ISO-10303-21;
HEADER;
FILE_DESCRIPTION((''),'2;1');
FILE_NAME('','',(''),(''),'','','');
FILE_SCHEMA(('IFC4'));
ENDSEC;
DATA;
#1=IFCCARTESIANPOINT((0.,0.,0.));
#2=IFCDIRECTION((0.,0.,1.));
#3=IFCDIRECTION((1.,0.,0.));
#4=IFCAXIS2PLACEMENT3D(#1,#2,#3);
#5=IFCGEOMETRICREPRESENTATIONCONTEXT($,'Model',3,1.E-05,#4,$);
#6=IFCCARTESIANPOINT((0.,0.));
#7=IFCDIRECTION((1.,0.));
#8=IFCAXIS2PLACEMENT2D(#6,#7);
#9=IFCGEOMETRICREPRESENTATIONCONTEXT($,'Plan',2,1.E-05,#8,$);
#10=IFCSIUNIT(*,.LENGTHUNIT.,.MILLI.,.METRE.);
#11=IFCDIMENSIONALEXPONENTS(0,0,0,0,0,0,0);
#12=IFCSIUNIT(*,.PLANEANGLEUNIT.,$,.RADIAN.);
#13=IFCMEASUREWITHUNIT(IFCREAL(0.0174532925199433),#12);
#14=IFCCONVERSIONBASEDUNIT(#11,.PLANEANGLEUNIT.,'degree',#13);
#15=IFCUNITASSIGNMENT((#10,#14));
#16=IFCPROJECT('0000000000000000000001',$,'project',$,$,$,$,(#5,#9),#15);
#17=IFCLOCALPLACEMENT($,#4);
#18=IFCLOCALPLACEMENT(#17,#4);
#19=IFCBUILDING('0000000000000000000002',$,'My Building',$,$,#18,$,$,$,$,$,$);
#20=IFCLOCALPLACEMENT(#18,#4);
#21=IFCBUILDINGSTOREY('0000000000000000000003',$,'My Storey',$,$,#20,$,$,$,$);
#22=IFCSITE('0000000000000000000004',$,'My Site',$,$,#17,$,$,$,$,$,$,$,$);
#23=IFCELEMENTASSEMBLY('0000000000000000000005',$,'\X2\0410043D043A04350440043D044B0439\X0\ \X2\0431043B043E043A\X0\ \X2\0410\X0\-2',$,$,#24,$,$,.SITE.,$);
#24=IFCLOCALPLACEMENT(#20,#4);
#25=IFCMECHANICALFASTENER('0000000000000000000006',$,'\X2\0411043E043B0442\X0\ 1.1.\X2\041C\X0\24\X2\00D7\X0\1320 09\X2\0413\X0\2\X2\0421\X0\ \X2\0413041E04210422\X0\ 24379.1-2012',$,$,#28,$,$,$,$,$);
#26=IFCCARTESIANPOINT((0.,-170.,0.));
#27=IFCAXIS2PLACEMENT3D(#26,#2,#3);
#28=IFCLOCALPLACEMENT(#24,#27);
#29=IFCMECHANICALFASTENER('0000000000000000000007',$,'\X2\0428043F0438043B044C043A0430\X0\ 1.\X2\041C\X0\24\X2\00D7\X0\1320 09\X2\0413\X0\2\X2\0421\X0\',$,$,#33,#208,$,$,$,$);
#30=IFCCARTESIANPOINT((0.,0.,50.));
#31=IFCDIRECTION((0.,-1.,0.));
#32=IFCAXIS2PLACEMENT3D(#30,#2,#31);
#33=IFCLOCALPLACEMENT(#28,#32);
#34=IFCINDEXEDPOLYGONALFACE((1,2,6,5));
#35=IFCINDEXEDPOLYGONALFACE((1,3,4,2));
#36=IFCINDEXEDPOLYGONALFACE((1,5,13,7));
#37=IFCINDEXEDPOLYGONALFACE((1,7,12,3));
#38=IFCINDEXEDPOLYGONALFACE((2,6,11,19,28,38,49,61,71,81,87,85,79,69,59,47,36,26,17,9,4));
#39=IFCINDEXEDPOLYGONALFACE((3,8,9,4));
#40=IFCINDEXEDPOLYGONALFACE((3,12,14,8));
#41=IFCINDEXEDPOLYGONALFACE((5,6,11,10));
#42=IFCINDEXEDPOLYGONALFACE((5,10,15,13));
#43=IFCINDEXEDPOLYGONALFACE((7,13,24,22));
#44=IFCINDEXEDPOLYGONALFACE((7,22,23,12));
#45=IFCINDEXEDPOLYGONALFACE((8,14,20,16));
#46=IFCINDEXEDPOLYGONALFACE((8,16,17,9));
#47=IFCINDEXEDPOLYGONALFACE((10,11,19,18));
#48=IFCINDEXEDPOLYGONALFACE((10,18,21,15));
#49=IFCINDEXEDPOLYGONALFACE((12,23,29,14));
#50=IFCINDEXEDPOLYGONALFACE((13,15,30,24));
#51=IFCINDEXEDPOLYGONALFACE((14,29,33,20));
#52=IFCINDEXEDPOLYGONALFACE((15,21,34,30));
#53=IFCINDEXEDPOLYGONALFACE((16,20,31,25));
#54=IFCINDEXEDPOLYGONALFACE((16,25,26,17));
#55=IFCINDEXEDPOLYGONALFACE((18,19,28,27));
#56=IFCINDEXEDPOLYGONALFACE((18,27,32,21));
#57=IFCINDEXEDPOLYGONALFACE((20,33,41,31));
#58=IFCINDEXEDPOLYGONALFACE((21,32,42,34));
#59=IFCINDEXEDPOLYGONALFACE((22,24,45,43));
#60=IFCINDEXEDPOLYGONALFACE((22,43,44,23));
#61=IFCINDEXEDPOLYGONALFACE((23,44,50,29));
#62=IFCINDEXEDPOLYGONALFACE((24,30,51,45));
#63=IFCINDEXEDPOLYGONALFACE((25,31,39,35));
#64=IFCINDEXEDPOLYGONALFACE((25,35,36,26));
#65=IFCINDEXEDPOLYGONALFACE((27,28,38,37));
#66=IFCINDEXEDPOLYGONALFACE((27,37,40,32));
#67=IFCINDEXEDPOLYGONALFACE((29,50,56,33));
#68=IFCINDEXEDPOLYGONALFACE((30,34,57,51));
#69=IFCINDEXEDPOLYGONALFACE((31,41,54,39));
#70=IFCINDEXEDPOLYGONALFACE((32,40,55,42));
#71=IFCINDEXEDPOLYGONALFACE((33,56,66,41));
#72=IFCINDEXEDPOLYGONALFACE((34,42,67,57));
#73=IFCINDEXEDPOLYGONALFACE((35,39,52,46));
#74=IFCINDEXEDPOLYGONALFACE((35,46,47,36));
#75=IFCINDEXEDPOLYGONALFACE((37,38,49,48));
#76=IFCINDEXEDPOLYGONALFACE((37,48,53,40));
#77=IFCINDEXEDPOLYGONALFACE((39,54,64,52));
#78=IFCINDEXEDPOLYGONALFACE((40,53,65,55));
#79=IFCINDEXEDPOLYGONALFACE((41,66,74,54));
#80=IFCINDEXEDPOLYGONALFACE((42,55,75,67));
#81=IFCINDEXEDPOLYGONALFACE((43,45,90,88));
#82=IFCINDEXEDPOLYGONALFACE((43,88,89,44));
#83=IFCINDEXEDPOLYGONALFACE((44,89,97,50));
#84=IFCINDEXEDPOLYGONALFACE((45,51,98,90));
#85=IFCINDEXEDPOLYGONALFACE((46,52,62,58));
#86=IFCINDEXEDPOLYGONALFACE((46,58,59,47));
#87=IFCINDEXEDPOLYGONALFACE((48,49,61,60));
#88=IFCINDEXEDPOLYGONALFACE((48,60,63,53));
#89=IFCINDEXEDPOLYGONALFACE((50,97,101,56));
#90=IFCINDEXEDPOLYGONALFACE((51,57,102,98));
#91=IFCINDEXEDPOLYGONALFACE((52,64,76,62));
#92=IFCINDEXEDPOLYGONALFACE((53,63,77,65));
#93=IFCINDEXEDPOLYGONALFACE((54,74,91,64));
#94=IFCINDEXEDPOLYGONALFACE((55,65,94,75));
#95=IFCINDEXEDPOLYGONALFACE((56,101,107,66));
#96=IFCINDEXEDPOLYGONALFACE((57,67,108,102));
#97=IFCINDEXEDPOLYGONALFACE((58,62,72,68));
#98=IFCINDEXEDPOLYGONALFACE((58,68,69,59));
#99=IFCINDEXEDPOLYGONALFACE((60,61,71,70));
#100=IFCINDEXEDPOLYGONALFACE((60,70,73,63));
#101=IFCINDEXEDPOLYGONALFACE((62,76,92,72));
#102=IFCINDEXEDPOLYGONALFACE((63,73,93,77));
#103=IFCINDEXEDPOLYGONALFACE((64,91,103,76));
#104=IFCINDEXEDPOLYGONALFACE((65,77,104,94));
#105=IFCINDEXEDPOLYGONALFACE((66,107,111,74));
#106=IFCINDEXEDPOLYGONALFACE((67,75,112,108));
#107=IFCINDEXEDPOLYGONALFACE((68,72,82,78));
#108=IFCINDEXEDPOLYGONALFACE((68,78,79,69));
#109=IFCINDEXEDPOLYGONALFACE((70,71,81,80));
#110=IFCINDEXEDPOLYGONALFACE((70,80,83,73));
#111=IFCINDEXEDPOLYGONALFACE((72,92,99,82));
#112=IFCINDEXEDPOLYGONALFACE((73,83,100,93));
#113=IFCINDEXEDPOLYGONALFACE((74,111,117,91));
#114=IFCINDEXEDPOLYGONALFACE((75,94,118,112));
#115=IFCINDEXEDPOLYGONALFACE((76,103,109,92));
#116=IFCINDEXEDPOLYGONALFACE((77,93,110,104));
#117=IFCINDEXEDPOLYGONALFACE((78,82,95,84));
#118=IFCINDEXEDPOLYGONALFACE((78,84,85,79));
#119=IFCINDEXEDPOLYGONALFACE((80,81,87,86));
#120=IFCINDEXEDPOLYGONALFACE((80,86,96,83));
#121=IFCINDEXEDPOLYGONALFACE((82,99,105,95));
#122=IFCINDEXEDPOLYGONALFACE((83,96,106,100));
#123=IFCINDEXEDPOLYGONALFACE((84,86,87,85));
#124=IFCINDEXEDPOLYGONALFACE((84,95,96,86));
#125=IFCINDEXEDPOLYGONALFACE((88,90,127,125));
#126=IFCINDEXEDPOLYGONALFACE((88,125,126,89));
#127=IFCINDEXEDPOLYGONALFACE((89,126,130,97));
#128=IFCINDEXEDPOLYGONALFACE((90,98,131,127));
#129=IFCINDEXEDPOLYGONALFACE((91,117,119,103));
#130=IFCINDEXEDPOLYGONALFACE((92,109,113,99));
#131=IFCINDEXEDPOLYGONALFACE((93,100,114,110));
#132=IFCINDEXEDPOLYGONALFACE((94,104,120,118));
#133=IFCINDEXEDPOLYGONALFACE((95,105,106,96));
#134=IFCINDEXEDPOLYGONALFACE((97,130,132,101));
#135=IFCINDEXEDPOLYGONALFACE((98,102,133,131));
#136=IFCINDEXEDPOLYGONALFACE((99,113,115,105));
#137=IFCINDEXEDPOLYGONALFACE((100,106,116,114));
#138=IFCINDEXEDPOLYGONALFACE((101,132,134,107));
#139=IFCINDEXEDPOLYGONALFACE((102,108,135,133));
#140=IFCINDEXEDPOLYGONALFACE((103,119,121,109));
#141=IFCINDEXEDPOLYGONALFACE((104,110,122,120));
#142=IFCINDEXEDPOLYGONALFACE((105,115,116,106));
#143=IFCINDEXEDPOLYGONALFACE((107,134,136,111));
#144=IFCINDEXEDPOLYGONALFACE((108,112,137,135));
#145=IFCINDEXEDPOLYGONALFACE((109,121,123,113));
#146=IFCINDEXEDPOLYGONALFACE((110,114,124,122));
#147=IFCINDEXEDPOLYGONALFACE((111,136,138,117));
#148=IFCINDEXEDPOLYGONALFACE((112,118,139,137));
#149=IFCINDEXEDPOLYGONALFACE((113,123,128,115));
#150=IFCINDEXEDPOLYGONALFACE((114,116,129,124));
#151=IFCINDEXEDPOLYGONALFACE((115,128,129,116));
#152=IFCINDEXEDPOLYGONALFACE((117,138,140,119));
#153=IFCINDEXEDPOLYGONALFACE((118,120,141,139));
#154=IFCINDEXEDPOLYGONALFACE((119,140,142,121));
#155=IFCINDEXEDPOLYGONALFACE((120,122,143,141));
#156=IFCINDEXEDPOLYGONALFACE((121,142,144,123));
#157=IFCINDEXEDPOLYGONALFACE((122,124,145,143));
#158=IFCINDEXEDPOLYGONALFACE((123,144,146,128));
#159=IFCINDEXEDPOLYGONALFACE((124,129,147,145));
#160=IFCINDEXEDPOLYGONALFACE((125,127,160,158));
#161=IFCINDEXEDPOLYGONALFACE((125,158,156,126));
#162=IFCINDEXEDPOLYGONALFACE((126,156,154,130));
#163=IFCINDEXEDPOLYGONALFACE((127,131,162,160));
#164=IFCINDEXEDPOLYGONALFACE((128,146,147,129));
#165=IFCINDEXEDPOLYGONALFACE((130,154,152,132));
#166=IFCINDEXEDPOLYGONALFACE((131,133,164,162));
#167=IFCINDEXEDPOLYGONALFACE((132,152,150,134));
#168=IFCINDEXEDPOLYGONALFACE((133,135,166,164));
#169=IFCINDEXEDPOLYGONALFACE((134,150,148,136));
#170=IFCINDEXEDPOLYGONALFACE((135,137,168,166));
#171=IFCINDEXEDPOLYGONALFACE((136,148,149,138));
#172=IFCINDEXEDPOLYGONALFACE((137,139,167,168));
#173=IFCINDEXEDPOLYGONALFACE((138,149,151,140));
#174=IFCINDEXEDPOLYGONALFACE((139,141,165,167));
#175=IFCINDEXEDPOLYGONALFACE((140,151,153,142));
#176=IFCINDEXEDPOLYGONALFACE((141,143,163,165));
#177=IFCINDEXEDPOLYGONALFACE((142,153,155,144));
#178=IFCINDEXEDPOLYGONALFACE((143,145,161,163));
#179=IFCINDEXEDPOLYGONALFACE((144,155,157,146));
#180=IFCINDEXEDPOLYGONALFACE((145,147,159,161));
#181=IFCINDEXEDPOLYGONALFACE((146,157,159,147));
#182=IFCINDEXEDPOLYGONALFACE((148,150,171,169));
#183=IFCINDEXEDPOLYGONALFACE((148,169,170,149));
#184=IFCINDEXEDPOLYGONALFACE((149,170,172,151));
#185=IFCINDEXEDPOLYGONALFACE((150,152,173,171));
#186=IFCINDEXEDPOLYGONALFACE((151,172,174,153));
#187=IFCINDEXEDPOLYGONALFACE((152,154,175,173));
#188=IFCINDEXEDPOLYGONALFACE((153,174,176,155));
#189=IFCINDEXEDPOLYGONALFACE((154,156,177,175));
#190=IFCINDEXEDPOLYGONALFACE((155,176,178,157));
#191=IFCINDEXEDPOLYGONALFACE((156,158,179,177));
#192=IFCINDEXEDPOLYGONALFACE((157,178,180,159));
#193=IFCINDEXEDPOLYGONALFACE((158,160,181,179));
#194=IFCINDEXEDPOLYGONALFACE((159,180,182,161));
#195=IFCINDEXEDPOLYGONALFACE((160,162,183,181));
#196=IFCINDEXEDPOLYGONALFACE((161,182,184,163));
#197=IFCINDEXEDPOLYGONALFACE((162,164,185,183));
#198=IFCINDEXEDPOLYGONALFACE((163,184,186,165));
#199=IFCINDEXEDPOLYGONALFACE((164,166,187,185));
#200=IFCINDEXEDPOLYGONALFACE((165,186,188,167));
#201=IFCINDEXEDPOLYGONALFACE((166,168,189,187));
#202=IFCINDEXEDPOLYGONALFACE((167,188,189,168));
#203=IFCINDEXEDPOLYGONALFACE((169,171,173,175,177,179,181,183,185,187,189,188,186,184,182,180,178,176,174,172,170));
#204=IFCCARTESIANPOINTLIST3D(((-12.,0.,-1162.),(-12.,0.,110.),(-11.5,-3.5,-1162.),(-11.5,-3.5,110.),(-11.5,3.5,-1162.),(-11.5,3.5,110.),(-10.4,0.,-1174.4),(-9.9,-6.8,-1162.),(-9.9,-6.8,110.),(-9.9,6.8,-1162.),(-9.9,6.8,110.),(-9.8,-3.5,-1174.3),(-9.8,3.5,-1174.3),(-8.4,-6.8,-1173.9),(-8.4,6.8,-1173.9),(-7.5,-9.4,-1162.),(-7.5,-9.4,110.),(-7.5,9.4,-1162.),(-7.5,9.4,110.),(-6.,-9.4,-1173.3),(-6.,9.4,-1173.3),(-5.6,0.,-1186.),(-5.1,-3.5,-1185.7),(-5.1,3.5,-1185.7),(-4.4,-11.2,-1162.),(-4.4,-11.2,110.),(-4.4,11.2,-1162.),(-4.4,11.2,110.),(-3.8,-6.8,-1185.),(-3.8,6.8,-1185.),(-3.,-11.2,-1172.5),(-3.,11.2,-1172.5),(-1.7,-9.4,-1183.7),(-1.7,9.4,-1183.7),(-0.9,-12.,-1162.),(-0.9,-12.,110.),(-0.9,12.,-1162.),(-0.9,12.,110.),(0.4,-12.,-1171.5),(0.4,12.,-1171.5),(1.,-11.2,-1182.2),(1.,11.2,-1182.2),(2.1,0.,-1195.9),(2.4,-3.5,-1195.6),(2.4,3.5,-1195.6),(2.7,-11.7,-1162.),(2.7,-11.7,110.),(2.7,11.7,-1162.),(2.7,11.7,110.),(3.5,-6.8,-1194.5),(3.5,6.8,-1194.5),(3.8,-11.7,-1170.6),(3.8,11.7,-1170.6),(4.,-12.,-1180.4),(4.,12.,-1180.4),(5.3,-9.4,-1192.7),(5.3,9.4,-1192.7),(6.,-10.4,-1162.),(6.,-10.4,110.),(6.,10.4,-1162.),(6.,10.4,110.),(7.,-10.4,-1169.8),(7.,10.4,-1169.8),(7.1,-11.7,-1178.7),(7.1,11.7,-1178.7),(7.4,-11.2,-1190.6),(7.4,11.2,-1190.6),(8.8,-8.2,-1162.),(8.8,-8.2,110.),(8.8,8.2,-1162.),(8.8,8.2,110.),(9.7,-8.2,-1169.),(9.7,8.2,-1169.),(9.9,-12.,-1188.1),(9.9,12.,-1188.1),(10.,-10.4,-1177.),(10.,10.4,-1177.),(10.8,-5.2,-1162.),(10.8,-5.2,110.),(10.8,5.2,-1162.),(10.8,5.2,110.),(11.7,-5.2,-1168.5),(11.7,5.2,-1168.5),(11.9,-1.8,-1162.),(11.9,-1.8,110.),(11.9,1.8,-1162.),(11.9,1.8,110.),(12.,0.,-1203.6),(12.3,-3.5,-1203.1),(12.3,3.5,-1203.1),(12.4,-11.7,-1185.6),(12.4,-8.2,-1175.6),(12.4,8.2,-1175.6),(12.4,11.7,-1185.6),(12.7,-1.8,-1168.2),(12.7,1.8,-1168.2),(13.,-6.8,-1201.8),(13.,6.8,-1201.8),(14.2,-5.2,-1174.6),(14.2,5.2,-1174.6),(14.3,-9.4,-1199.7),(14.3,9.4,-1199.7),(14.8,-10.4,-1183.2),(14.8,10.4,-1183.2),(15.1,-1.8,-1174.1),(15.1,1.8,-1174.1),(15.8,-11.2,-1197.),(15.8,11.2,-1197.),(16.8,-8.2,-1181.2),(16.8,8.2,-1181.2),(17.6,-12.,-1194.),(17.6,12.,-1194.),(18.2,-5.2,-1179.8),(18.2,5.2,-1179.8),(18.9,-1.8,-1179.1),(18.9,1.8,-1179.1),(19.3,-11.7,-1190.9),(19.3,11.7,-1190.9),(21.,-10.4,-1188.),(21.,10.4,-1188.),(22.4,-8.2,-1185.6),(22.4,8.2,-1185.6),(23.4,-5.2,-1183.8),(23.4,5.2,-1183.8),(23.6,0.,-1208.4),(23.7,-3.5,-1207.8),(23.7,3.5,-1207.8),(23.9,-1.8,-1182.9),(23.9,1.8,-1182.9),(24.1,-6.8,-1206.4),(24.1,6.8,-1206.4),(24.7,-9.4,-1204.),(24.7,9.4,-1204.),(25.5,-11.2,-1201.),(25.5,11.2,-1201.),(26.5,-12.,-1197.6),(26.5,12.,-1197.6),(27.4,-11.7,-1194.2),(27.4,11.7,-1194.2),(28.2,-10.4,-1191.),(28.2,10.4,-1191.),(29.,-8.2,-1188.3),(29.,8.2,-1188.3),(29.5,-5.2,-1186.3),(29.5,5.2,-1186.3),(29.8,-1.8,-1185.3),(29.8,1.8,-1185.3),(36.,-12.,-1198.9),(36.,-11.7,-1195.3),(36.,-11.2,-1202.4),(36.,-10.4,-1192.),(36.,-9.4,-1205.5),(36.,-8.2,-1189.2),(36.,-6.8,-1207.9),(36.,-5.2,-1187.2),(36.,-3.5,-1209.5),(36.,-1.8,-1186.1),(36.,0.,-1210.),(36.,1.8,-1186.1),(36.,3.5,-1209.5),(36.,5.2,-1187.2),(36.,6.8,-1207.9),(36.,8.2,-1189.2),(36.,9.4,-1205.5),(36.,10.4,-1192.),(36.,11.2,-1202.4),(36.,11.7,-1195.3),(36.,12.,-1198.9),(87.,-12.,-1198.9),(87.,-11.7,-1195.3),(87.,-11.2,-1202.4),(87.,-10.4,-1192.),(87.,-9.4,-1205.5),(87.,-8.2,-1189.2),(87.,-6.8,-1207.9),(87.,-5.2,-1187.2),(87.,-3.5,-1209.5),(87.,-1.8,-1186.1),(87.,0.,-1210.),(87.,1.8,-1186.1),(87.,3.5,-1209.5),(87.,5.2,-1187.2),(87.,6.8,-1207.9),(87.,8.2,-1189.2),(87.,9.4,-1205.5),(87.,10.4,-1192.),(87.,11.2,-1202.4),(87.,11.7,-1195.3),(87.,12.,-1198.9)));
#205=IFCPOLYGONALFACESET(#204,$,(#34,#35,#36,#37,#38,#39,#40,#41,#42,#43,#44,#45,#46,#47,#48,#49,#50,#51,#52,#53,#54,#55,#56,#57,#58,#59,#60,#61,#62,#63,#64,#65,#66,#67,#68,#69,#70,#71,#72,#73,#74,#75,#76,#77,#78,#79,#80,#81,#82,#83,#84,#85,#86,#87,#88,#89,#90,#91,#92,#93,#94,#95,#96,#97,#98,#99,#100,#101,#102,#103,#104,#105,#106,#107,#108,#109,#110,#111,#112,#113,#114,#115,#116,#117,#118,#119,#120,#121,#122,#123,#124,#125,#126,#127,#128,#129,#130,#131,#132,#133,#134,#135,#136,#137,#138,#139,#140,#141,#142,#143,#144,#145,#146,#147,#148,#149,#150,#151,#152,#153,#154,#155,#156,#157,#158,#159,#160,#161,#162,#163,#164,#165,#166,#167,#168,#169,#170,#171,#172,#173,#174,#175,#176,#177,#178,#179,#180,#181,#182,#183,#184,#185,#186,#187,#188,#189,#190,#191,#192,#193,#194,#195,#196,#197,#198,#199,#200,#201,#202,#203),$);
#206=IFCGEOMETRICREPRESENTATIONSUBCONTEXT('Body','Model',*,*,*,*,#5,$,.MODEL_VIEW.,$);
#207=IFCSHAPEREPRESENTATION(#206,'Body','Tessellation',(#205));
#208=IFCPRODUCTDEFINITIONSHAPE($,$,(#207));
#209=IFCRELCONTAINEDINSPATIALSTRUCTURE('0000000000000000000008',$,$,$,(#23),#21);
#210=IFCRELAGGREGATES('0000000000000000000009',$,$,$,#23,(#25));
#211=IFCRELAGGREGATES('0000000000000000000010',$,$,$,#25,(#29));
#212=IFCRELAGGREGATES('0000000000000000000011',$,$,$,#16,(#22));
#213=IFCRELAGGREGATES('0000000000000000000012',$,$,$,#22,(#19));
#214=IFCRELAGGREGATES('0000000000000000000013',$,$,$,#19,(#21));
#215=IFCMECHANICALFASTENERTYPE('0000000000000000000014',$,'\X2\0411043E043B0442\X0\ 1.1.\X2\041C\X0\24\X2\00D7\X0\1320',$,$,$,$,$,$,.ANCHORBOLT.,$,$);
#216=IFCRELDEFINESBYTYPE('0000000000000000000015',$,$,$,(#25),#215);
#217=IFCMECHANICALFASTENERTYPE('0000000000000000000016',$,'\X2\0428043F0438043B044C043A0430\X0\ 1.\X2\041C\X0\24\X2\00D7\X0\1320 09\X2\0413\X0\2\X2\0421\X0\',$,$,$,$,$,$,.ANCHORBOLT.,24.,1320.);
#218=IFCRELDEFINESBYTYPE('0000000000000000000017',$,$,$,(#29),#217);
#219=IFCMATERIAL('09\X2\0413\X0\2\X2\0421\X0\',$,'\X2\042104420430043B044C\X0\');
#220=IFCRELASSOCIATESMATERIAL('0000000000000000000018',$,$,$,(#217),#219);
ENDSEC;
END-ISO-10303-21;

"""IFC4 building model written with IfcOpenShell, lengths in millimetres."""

from ifc_helpers import new_model, entity, si_unit, converted_unit, frame, origin_with_axes, origin_2d_with_axis, place, context, subcontext, project, spatial, source, transform, mapped, material, type_object, type_shapes, element, aggregate, save


model = new_model("IFC4")

# Units and contexts
model_context = context("Model", 3, precision=1e-05, world=origin_with_axes())
plan_context = context("Plan", 2, precision=1e-05, world=origin_2d_with_axis())
body_context = subcontext(model_context, "Body", "Model", "MODEL_VIEW")
ifc_project = project(units=[si_unit("LENGTHUNIT", "METRE", prefix="MILLI"), converted_unit("PLANEANGLEUNIT", "degree", entity("IfcReal", 0.0174532925199433), si_unit("PLANEANGLEUNIT", "RADIAN"), dimensions=[0, 0, 0, 0, 0, 0, 0])], contexts=[model_context, plan_context])

# Site, building, storey
site_placement = place(None, origin_with_axes())
site = spatial("IfcSite", under=ifc_project, at=site_placement, Name="My Site")
building_placement = place(site_placement, origin_with_axes())
building = spatial("IfcBuilding", under=site, at=building_placement, Name="My Building")
storey_placement = place(building_placement, origin_with_axes())
storey = spatial("IfcBuildingStorey", under=building, at=storey_placement, Name="My Storey")

# Shared definitions
placement_1 = place(storey_placement, origin_with_axes())

# Element assembly, mechanical fasteners
assembly_1 = element("IfcElementAssembly", 1, at=placement_1, inside=storey, Name="Анкерный блок А-2", AssemblyPlace="SITE")
mechanical_fastener_type_1 = type_object("IfcMechanicalFastenerType", Name="Болт 1.1.М24×1320", PredefinedType="ANCHORBOLT")
mechanical_fastener_1_placement = place(placement_1, frame((0.0, -170.0, 0.0), z_axis=(0.0, 0.0, 1.0), x_axis=(1.0, 0.0, 0.0)))
mechanical_fastener_1 = element("IfcMechanicalFastener", 2, at=mechanical_fastener_1_placement, type_object=mechanical_fastener_type_1, Name="Болт 1.1.М24×1320 09Г2С ГОСТ 24379.1-2012")
ifc_material_1 = material(Name="09Г2С", Category="Сталь")
mechanical_fastener_type_2 = type_object("IfcMechanicalFastenerType", Name="Шпилька 1.М24×1320 09Г2С", NominalDiameter=24.0, NominalLength=1320.0, PredefinedType="ANCHORBOLT", material=ifc_material_1)
shared_shape_1 = source(frame((0.0, 0.0, 110.0), z_axis=(0.0, 0.0, 1.0), x_axis=(1.0, 0.0, 0.0)), body_context, "Body", "AdvancedSweptSolid", [
    entity("IfcSweptDiskSolid", entity("IfcIndexedPolyCurve", entity("IfcCartesianPointList3D", [[0.0, 0.0, 0.0], [0.0, 0.0, -1272.0], [10.5, 0.0, -1297.5], [36.0, 0.0, -1308.0], [87.0, 0.0, -1308.0]]), [entity("IfcLineIndex", [1, 2]), entity("IfcArcIndex", [2, 3, 4]), entity("IfcLineIndex", [4, 5])]), 12.0),
])
type_shapes(mechanical_fastener_type_2, [shared_shape_1])
mechanical_fastener_2_placement = place(mechanical_fastener_1_placement, frame((0.0, 0.0, 50.0), z_axis=(0.0, 0.0, 1.0), x_axis=(0.0, -1.0, 0.0)))
mechanical_fastener_2 = element("IfcMechanicalFastener", 3, at=mechanical_fastener_2_placement, type_object=mechanical_fastener_type_2, Name="Шпилька 1.М24×1320 09Г2С", context=body_context, shape_type="MappedRepresentation", body=[
    mapped(shared_shape_1, transform((0.0, 0.0, 0.0), x_axis=(1.0, 0.0, 0.0), y_axis=(0.0, 1.0, 0.0), z_axis=(0.0, 0.0, 1.0), scale=1.0)),
])
aggregate(assembly_1, [mechanical_fastener_1])

aggregate(mechanical_fastener_1, [mechanical_fastener_2])

save(model, "model.ifc")
